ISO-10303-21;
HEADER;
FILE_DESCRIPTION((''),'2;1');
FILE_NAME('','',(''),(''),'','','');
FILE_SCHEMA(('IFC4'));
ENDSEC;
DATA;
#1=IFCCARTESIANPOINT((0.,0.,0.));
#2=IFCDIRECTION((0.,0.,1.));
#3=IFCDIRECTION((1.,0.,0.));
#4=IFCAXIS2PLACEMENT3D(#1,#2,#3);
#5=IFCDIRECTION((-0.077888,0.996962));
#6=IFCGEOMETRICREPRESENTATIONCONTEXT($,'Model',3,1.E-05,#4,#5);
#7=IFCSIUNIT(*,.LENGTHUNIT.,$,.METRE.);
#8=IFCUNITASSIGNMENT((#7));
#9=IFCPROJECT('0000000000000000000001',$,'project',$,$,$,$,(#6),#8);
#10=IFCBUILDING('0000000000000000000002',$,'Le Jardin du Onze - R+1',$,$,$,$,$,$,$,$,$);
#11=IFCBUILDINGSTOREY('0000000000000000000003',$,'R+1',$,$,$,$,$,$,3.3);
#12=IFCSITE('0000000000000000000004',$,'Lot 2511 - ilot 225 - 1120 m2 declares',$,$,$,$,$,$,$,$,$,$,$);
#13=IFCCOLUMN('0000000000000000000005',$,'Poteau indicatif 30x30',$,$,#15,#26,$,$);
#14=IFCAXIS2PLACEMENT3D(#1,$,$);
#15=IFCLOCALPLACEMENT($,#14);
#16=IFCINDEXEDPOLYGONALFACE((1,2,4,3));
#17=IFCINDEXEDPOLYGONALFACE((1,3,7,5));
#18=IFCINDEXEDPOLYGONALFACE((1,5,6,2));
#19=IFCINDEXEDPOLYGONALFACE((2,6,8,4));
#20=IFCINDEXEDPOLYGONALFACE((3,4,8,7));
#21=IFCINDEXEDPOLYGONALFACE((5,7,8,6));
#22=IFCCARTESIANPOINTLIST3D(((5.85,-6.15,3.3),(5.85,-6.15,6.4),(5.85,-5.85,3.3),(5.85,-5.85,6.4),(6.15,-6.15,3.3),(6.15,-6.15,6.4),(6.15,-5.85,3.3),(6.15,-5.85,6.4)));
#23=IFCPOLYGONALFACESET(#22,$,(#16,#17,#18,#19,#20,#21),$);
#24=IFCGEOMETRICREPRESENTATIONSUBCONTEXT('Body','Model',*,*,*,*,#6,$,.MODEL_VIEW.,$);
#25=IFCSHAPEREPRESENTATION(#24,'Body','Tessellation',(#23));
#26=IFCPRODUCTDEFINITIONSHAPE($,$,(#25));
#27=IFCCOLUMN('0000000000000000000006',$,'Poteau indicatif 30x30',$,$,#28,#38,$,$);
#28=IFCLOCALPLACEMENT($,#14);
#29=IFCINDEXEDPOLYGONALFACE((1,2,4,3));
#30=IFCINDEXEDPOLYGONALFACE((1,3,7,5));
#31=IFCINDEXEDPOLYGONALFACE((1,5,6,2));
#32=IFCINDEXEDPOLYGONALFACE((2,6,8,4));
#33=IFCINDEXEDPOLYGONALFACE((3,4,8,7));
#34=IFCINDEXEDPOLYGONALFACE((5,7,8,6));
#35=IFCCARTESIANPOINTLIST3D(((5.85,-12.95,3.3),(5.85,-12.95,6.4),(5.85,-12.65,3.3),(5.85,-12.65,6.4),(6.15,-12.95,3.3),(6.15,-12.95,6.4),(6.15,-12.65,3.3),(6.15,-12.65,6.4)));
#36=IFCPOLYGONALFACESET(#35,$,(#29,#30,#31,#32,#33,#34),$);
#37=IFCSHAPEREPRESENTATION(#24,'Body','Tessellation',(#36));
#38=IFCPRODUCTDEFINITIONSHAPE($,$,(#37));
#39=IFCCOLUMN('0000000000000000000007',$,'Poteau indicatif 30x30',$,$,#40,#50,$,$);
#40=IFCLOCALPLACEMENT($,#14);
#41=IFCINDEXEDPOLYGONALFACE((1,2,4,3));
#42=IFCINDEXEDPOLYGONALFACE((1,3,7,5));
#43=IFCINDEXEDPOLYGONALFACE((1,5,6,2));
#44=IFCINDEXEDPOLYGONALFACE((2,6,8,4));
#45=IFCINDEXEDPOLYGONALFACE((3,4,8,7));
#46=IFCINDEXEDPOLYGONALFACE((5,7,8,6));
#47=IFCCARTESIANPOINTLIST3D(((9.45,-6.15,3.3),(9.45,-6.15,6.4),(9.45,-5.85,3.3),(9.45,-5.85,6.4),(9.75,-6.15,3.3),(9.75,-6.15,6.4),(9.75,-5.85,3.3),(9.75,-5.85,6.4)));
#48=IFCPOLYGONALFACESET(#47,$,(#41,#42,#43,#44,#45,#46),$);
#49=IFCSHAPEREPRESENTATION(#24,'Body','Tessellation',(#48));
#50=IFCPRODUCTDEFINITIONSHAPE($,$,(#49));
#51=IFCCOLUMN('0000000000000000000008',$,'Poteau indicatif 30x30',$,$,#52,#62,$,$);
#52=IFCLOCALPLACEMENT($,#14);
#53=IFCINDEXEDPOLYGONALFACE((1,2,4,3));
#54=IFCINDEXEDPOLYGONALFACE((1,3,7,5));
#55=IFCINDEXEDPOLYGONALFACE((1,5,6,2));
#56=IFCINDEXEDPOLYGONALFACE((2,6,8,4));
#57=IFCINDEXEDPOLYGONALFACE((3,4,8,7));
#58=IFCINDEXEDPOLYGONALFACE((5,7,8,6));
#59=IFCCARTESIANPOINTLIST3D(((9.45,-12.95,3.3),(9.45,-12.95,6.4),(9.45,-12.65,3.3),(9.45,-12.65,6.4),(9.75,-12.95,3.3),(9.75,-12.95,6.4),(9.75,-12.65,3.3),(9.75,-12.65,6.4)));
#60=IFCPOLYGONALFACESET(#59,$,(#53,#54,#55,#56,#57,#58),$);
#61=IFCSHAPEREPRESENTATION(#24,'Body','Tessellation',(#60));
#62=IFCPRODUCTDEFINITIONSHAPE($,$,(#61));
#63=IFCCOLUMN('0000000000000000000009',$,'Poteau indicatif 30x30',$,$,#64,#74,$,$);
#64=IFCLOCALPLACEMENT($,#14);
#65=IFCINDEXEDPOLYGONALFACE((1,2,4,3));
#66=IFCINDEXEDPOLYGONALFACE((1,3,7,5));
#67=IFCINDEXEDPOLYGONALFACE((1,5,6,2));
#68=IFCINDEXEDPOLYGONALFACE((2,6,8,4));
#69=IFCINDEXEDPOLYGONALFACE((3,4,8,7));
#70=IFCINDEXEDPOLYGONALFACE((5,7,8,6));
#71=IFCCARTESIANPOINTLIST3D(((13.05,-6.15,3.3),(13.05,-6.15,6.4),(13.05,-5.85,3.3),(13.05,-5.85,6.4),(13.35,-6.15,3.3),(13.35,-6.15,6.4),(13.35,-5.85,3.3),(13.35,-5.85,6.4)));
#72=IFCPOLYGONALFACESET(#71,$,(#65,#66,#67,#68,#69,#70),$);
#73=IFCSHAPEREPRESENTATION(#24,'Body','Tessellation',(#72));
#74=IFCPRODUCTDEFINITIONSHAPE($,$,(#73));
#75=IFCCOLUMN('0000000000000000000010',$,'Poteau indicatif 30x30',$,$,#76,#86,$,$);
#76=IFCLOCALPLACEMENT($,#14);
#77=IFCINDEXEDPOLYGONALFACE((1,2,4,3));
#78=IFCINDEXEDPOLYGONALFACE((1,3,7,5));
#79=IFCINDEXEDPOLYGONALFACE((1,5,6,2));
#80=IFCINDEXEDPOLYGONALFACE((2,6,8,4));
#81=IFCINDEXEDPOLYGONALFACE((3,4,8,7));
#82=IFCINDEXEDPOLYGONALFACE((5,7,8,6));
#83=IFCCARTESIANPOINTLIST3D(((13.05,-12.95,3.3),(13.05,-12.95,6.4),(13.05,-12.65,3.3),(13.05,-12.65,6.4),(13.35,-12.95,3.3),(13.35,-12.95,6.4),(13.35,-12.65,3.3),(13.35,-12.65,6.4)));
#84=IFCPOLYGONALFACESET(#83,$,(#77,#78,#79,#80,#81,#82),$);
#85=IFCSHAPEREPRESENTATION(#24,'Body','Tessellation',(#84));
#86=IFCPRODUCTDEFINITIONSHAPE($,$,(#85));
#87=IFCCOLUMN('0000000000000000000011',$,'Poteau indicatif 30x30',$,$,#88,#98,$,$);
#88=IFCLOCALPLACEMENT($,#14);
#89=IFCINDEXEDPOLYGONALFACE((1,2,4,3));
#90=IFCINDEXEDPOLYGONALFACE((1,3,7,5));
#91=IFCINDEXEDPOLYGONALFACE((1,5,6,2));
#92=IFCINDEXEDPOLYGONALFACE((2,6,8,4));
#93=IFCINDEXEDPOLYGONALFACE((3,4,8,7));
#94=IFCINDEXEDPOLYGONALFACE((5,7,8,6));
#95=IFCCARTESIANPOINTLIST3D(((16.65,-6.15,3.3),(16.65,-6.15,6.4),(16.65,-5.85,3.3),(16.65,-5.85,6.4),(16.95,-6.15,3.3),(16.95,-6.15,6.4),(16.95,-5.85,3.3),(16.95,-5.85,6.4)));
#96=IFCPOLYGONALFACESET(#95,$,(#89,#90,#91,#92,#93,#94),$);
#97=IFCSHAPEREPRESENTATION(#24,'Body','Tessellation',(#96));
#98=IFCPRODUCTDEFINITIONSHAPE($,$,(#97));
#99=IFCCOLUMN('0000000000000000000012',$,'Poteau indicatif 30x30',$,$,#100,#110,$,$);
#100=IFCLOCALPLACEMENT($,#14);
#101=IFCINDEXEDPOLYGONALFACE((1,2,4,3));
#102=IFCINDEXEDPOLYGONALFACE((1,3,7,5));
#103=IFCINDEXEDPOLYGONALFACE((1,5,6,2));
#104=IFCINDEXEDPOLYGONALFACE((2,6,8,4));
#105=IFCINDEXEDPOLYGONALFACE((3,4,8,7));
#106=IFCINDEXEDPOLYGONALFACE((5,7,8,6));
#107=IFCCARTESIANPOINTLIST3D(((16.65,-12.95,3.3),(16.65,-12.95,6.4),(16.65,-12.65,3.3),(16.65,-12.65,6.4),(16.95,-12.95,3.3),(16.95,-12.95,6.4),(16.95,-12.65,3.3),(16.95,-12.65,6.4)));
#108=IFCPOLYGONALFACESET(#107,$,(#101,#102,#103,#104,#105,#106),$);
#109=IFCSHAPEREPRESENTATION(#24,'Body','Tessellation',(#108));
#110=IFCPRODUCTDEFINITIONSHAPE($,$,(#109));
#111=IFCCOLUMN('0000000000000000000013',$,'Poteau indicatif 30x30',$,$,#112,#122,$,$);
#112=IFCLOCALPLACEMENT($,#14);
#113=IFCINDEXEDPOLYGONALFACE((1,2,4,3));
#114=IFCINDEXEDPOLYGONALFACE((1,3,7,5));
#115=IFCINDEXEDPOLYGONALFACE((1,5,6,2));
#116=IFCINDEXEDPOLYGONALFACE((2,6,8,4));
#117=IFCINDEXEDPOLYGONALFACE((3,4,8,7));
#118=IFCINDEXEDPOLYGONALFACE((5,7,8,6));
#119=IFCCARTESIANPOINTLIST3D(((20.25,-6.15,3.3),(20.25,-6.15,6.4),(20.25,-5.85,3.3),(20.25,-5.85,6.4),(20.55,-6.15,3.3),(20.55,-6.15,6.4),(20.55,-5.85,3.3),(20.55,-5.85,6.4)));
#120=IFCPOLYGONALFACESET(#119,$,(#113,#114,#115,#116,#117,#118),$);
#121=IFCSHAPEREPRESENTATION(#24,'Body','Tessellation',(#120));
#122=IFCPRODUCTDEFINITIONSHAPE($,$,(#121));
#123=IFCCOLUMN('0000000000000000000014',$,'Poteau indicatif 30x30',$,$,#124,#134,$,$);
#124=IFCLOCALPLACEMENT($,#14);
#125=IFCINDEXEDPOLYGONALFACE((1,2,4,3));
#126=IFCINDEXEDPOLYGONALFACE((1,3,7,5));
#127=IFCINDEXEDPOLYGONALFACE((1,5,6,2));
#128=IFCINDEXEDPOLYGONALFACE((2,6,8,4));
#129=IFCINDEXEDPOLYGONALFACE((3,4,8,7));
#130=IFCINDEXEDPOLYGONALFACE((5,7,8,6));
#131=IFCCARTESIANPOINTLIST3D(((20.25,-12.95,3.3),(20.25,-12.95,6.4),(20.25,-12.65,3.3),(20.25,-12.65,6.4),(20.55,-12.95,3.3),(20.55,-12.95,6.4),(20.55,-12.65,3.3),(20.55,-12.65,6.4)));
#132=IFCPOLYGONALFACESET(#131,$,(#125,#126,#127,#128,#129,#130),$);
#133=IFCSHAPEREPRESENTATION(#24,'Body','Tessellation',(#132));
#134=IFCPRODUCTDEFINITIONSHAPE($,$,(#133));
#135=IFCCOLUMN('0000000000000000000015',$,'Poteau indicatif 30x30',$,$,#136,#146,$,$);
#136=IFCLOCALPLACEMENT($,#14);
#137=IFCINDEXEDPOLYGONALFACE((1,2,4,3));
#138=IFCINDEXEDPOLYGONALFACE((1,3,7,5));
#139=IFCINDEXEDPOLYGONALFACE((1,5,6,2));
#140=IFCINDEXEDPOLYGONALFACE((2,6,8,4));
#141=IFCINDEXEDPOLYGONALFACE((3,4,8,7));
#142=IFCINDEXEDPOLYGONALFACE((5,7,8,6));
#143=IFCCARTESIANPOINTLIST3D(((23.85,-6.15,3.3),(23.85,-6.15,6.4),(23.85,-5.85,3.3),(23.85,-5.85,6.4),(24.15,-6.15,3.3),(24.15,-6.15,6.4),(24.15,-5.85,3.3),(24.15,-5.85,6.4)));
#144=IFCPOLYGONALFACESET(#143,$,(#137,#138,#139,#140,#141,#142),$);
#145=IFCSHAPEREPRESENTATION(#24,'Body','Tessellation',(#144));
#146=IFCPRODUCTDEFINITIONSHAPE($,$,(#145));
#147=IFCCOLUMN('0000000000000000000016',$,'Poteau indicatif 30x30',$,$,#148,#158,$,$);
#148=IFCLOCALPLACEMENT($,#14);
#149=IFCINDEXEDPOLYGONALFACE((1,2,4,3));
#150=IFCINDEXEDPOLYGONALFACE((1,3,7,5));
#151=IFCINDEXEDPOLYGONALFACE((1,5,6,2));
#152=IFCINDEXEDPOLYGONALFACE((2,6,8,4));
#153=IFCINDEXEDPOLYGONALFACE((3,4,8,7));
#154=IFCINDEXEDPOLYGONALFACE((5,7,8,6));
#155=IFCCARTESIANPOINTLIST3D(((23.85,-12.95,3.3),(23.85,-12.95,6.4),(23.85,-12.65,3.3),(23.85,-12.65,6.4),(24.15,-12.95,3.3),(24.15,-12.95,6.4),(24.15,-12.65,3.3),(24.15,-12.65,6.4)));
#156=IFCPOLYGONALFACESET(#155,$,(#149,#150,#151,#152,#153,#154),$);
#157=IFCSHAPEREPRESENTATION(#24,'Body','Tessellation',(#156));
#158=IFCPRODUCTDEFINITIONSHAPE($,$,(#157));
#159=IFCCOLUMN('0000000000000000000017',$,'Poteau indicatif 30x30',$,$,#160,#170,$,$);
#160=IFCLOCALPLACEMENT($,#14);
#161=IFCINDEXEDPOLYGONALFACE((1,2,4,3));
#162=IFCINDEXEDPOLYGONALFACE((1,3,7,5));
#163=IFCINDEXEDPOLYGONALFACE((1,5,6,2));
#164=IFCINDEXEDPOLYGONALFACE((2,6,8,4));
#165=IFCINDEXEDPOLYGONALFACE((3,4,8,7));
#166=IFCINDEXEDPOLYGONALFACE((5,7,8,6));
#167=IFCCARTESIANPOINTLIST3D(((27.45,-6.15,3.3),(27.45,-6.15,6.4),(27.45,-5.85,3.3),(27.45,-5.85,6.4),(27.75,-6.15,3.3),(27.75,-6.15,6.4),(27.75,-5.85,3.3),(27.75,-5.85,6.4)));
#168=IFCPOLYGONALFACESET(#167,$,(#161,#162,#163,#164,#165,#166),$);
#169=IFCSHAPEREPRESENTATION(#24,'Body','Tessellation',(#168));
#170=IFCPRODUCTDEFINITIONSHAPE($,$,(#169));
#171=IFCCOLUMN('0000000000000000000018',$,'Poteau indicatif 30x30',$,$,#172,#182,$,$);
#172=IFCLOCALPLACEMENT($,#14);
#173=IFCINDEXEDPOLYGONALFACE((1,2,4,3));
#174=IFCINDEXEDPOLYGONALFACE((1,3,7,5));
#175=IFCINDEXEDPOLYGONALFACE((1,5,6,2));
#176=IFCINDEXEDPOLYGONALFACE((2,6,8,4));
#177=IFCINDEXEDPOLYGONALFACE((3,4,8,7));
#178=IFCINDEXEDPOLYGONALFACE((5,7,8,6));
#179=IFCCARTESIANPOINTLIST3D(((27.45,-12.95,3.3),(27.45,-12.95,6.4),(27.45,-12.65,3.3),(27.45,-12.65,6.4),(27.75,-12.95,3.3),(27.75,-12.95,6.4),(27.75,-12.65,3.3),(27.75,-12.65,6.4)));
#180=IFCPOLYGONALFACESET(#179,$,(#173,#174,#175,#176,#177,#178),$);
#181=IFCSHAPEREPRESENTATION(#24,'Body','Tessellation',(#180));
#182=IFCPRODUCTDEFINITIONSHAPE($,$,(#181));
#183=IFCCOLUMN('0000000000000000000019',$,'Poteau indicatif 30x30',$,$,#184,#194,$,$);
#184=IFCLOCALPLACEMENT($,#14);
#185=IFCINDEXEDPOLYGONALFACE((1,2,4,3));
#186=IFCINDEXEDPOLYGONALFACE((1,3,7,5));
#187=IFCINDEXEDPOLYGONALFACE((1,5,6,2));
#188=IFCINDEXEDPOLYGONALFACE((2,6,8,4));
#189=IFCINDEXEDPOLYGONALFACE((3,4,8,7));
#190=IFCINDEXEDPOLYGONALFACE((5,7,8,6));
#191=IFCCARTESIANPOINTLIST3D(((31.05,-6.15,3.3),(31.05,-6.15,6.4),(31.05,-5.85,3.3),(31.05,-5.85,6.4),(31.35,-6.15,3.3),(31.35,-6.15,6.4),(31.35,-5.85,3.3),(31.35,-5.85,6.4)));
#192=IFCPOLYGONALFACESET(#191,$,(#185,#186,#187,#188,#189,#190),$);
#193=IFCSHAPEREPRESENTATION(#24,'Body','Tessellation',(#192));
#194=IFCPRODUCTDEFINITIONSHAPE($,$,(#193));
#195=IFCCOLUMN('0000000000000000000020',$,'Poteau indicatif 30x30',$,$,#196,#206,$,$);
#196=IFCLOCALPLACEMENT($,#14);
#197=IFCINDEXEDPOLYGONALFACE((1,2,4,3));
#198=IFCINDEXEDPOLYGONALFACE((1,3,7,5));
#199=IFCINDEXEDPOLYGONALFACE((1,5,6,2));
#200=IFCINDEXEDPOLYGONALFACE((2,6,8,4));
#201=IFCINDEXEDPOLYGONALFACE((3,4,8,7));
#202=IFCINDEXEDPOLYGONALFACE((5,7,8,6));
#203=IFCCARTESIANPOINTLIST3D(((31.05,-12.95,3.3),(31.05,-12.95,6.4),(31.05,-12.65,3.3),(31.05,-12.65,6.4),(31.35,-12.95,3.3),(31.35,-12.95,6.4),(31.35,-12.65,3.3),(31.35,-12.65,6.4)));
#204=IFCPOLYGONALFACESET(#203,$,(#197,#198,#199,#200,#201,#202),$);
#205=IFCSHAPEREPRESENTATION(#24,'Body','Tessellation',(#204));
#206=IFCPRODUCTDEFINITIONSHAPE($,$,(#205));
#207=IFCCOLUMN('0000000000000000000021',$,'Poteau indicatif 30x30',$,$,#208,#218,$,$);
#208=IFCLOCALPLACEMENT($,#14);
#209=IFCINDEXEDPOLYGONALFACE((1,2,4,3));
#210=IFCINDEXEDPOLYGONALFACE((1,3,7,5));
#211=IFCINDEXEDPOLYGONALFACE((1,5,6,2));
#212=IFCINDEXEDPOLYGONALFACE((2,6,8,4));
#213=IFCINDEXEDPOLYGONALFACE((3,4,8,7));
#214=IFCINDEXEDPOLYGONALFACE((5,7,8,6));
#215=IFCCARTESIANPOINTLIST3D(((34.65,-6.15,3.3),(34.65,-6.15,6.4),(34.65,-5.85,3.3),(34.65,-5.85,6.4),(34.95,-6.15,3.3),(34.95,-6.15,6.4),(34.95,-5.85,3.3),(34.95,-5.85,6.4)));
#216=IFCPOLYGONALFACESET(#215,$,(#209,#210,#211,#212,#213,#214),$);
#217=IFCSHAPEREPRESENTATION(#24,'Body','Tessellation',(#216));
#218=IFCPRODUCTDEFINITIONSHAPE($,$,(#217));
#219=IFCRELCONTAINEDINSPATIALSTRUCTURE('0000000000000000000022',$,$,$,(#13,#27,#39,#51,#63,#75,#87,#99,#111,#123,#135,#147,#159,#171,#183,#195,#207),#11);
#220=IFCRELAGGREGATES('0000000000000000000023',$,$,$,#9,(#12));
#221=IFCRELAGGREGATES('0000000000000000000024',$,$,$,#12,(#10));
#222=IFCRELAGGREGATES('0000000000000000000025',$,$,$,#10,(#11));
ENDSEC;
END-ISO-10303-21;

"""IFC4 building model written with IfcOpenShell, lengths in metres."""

from ifc_helpers import new_model, si_unit, direction, frame, origin_with_axes, place, context, subcontext, project, spatial, polyline, outline, extrude, element, save


model = new_model("IFC4")

# Units and contexts
model_context = context("Model", 3, precision=1e-05, world=origin_with_axes(), true_north=direction((-0.077888, 0.996962)))
body_context = subcontext(model_context, "Body", "Model", "MODEL_VIEW")
ifc_project = project(units=[si_unit("LENGTHUNIT", "METRE")], contexts=[model_context])

# Site, building, storey
site = spatial("IfcSite", under=ifc_project, Name="Lot 2511 - ilot 225 - 1120 m2 declares")
building = spatial("IfcBuilding", under=site, Name="Le Jardin du Onze - R+1")
storey = spatial("IfcBuildingStorey", under=building, Name="R+1", Elevation=3.3)

# Columns
column_1_placement = place(None, origin_with_axes())
element("IfcColumn", 1, at=column_1_placement, inside=storey, Name="Poteau indicatif 30x30", context=body_context, shape_type="SweptSolid", body=[
    extrude(outline(polyline([(6.15, -6.15), (6.15, -5.85), (5.85, -5.85), (5.85, -6.15), (6.15, -6.15)])), frame((0.0, 0.0, 3.3)), (0.0, 0.0, 1.0), 3.1),
])
column_2_placement = place(None, origin_with_axes())
element("IfcColumn", 2, at=column_2_placement, inside=storey, Name="Poteau indicatif 30x30", context=body_context, shape_type="SweptSolid", body=[
    extrude(outline(polyline([(6.15, -12.95), (6.15, -12.65), (5.85, -12.65), (5.85, -12.95), (6.15, -12.95)])), frame((0.0, 0.0, 3.3)), (0.0, 0.0, 1.0), 3.1),
])
column_3_placement = place(None, origin_with_axes())
element("IfcColumn", 3, at=column_3_placement, inside=storey, Name="Poteau indicatif 30x30", context=body_context, shape_type="SweptSolid", body=[
    extrude(outline(polyline([(9.75, -6.15), (9.75, -5.85), (9.45, -5.85), (9.45, -6.15), (9.75, -6.15)])), frame((0.0, 0.0, 3.3)), (0.0, 0.0, 1.0), 3.1),
])
column_4_placement = place(None, origin_with_axes())
element("IfcColumn", 4, at=column_4_placement, inside=storey, Name="Poteau indicatif 30x30", context=body_context, shape_type="SweptSolid", body=[
    extrude(outline(polyline([(9.75, -12.95), (9.75, -12.65), (9.45, -12.65), (9.45, -12.95), (9.75, -12.95)])), frame((0.0, 0.0, 3.3)), (0.0, 0.0, 1.0), 3.1),
])
column_5_placement = place(None, origin_with_axes())
element("IfcColumn", 5, at=column_5_placement, inside=storey, Name="Poteau indicatif 30x30", context=body_context, shape_type="SweptSolid", body=[
    extrude(outline(polyline([(13.35, -6.15), (13.35, -5.85), (13.05, -5.85), (13.05, -6.15), (13.35, -6.15)])), frame((0.0, 0.0, 3.3)), (0.0, 0.0, 1.0), 3.1),
])
column_6_placement = place(None, origin_with_axes())
element("IfcColumn", 6, at=column_6_placement, inside=storey, Name="Poteau indicatif 30x30", context=body_context, shape_type="SweptSolid", body=[
    extrude(outline(polyline([(13.35, -12.95), (13.35, -12.65), (13.05, -12.65), (13.05, -12.95), (13.35, -12.95)])), frame((0.0, 0.0, 3.3)), (0.0, 0.0, 1.0), 3.1),
])
column_7_placement = place(None, origin_with_axes())
element("IfcColumn", 7, at=column_7_placement, inside=storey, Name="Poteau indicatif 30x30", context=body_context, shape_type="SweptSolid", body=[
    extrude(outline(polyline([(16.95, -6.15), (16.95, -5.85), (16.65, -5.85), (16.65, -6.15), (16.95, -6.15)])), frame((0.0, 0.0, 3.3)), (0.0, 0.0, 1.0), 3.1),
])
column_8_placement = place(None, origin_with_axes())
element("IfcColumn", 8, at=column_8_placement, inside=storey, Name="Poteau indicatif 30x30", context=body_context, shape_type="SweptSolid", body=[
    extrude(outline(polyline([(16.95, -12.95), (16.95, -12.65), (16.65, -12.65), (16.65, -12.95), (16.95, -12.95)])), frame((0.0, 0.0, 3.3)), (0.0, 0.0, 1.0), 3.1),
])
column_9_placement = place(None, origin_with_axes())
element("IfcColumn", 9, at=column_9_placement, inside=storey, Name="Poteau indicatif 30x30", context=body_context, shape_type="SweptSolid", body=[
    extrude(outline(polyline([(20.55, -6.15), (20.55, -5.85), (20.25, -5.85), (20.25, -6.15), (20.55, -6.15)])), frame((0.0, 0.0, 3.3)), (0.0, 0.0, 1.0), 3.1),
])
column_10_placement = place(None, origin_with_axes())
element("IfcColumn", 10, at=column_10_placement, inside=storey, Name="Poteau indicatif 30x30", context=body_context, shape_type="SweptSolid", body=[
    extrude(outline(polyline([(20.55, -12.95), (20.55, -12.65), (20.25, -12.65), (20.25, -12.95), (20.55, -12.95)])), frame((0.0, 0.0, 3.3)), (0.0, 0.0, 1.0), 3.1),
])
column_11_placement = place(None, origin_with_axes())
element("IfcColumn", 11, at=column_11_placement, inside=storey, Name="Poteau indicatif 30x30", context=body_context, shape_type="SweptSolid", body=[
    extrude(outline(polyline([(24.15, -6.15), (24.15, -5.85), (23.85, -5.85), (23.85, -6.15), (24.15, -6.15)])), frame((0.0, 0.0, 3.3)), (0.0, 0.0, 1.0), 3.1),
])
column_12_placement = place(None, origin_with_axes())
element("IfcColumn", 12, at=column_12_placement, inside=storey, Name="Poteau indicatif 30x30", context=body_context, shape_type="SweptSolid", body=[
    extrude(outline(polyline([(24.15, -12.95), (24.15, -12.65), (23.85, -12.65), (23.85, -12.95), (24.15, -12.95)])), frame((0.0, 0.0, 3.3)), (0.0, 0.0, 1.0), 3.1),
])
column_13_placement = place(None, origin_with_axes())
element("IfcColumn", 13, at=column_13_placement, inside=storey, Name="Poteau indicatif 30x30", context=body_context, shape_type="SweptSolid", body=[
    extrude(outline(polyline([(27.75, -6.15), (27.75, -5.85), (27.45, -5.85), (27.45, -6.15), (27.75, -6.15)])), frame((0.0, 0.0, 3.3)), (0.0, 0.0, 1.0), 3.1),
])
column_14_placement = place(None, origin_with_axes())
element("IfcColumn", 14, at=column_14_placement, inside=storey, Name="Poteau indicatif 30x30", context=body_context, shape_type="SweptSolid", body=[
    extrude(outline(polyline([(27.75, -12.95), (27.75, -12.65), (27.45, -12.65), (27.45, -12.95), (27.75, -12.95)])), frame((0.0, 0.0, 3.3)), (0.0, 0.0, 1.0), 3.1),
])
column_15_placement = place(None, origin_with_axes())
element("IfcColumn", 15, at=column_15_placement, inside=storey, Name="Poteau indicatif 30x30", context=body_context, shape_type="SweptSolid", body=[
    extrude(outline(polyline([(31.35, -6.15), (31.35, -5.85), (31.05, -5.85), (31.05, -6.15), (31.35, -6.15)])), frame((0.0, 0.0, 3.3)), (0.0, 0.0, 1.0), 3.1),
])
column_16_placement = place(None, origin_with_axes())
element("IfcColumn", 16, at=column_16_placement, inside=storey, Name="Poteau indicatif 30x30", context=body_context, shape_type="SweptSolid", body=[
    extrude(outline(polyline([(31.35, -12.95), (31.35, -12.65), (31.05, -12.65), (31.05, -12.95), (31.35, -12.95)])), frame((0.0, 0.0, 3.3)), (0.0, 0.0, 1.0), 3.1),
])
column_17_placement = place(None, origin_with_axes())
element("IfcColumn", 17, at=column_17_placement, inside=storey, Name="Poteau indicatif 30x30", context=body_context, shape_type="SweptSolid", body=[
    extrude(outline(polyline([(34.95, -6.15), (34.95, -5.85), (34.65, -5.85), (34.65, -6.15), (34.95, -6.15)])), frame((0.0, 0.0, 3.3)), (0.0, 0.0, 1.0), 3.1),
])

save(model, "model.ifc")
